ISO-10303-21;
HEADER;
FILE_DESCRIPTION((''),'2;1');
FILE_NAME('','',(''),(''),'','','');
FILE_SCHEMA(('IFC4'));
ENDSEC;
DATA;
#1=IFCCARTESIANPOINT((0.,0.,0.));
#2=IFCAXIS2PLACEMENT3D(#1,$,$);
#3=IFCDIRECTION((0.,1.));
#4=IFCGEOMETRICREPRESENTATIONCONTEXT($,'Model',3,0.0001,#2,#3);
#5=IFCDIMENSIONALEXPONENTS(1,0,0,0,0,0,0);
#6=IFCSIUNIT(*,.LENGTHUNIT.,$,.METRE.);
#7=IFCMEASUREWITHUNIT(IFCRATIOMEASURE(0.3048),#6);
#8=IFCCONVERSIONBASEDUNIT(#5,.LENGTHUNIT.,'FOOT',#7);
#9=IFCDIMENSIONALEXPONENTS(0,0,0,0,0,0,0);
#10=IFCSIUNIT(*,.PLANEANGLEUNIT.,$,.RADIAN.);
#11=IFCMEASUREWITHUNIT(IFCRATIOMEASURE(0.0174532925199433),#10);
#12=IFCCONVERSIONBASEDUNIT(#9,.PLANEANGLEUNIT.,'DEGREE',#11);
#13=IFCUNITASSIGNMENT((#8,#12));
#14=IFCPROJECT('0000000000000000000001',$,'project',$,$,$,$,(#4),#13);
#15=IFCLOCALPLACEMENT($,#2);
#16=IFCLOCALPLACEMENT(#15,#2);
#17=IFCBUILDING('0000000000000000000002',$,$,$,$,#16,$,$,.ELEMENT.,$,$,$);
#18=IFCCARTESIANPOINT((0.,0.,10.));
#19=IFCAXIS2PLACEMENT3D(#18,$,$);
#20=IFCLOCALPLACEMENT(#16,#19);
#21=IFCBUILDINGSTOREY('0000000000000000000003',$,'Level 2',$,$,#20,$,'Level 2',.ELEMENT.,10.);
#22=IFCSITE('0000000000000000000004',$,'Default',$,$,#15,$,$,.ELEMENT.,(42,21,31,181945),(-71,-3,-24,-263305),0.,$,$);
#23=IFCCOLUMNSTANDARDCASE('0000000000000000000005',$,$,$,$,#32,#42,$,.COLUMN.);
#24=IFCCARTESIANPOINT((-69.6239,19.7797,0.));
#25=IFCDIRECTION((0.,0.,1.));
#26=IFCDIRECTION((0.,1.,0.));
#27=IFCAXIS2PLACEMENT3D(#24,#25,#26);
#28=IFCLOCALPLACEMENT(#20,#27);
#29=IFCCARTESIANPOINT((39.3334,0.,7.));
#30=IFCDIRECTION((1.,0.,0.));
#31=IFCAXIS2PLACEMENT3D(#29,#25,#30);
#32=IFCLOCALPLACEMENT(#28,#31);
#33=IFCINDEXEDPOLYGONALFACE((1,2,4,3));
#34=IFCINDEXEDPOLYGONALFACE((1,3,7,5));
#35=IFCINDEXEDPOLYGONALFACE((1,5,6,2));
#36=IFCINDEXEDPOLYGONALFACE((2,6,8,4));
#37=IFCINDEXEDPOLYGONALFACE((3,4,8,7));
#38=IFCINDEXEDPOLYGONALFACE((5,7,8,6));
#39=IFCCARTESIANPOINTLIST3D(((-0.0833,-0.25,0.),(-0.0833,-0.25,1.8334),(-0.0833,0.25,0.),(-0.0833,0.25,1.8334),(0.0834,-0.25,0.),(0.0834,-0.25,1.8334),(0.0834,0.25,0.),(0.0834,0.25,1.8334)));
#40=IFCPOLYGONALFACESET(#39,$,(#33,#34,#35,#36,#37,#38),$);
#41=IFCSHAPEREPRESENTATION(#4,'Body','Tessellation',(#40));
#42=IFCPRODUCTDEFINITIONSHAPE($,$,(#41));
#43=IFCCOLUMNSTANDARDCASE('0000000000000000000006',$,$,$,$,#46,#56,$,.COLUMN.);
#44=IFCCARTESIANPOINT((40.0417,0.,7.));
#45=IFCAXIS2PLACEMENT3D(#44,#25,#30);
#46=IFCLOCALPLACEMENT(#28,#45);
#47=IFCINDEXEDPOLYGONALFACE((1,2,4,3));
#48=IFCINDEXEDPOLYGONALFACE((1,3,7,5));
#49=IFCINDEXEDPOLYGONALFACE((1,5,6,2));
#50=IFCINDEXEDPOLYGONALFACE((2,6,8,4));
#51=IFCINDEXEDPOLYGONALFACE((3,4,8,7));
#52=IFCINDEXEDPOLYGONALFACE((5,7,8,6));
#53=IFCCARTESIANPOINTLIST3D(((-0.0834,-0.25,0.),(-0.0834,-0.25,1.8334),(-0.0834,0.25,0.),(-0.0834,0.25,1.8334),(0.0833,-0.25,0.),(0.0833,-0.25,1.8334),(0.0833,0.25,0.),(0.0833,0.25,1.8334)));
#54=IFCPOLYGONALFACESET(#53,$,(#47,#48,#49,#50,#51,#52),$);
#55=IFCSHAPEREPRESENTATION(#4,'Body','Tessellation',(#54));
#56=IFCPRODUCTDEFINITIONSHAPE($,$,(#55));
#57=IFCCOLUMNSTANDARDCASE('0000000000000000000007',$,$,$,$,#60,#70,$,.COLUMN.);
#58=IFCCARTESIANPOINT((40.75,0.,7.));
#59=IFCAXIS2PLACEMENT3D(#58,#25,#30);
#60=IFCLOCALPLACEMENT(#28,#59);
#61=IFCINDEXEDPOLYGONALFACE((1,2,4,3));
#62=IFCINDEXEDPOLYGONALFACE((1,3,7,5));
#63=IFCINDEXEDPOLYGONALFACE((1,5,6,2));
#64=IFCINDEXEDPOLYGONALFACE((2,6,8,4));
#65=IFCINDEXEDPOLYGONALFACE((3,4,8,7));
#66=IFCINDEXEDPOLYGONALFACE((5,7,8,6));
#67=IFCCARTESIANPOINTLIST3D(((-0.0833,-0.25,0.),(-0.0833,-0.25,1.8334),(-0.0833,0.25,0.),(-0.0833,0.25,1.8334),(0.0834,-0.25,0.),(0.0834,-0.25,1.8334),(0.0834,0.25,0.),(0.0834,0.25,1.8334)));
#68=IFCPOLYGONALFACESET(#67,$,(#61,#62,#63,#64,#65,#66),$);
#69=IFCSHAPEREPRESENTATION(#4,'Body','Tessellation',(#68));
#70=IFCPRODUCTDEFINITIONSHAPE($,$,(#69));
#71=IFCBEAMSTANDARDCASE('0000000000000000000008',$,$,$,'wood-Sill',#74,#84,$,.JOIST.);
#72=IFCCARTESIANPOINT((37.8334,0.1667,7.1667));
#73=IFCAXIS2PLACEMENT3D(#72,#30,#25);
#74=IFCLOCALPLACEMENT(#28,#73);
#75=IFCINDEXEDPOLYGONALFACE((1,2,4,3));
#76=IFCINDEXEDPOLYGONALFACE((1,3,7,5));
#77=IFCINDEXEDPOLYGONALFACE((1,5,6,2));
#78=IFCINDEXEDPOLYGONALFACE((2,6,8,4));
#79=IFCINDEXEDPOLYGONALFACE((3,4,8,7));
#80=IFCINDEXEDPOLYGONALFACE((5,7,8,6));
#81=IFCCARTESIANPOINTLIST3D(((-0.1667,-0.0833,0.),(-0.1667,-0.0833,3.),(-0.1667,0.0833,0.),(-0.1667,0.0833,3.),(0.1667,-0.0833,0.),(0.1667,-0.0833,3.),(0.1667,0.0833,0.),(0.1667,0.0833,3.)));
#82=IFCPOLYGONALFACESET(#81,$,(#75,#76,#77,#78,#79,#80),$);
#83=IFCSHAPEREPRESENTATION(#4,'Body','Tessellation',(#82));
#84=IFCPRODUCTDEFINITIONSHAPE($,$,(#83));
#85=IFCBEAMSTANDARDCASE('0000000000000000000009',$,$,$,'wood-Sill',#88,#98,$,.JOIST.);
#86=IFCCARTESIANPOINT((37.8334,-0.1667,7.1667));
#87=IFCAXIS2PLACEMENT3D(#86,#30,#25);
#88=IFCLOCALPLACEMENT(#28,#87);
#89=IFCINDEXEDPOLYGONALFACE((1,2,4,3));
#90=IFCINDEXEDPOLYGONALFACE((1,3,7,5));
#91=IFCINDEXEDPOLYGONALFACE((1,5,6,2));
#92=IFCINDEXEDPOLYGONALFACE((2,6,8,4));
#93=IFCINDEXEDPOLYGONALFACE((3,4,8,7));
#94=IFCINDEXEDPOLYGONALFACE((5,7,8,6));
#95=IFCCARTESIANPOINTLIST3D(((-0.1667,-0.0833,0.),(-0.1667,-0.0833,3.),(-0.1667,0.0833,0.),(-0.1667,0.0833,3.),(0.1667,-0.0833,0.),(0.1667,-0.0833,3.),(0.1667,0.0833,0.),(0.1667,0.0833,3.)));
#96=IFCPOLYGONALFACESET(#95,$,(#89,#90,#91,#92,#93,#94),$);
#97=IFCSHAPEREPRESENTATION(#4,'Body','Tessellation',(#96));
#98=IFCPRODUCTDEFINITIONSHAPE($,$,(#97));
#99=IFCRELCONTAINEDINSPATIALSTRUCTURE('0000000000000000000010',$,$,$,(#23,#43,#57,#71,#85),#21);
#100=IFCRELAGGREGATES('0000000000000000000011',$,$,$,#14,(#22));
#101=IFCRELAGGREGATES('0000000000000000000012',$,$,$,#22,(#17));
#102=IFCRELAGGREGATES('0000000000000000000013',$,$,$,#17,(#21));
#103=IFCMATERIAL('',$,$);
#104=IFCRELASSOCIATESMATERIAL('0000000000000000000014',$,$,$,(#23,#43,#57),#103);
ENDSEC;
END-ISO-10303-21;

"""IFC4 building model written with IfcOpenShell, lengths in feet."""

from ifc_helpers import new_model, entity, si_unit, converted_unit, direction, frame, origin, origin_with_axes, place, context, project, spatial, rectangle, extrude, material, element, save


model = new_model("IFC4")

# Units and contexts
model_context = context("Model", 3, precision=0.0001, world=origin(), true_north=direction((0.0, 1.0)))
ifc_project = project(units=[converted_unit("LENGTHUNIT", "FOOT", entity("IfcRatioMeasure", 0.3048), si_unit("LENGTHUNIT", "METRE"), dimensions=[1, 0, 0, 0, 0, 0, 0]), converted_unit("PLANEANGLEUNIT", "DEGREE", entity("IfcRatioMeasure", 0.0174532925199433), si_unit("PLANEANGLEUNIT", "RADIAN"), dimensions=[0, 0, 0, 0, 0, 0, 0])], contexts=[model_context])

# Site, building, storey
site_placement = place(None, origin())
site = spatial("IfcSite", under=ifc_project, at=site_placement, Name="Default", CompositionType="ELEMENT", RefLatitude=(42, 21, 31, 181945), RefLongitude=(-71, -3, -24, -263305), RefElevation=0.0)
building_placement = place(site_placement, origin())
building = spatial("IfcBuilding", under=site, at=building_placement, CompositionType="ELEMENT")
storey_placement = place(building_placement, frame((0.0, 0.0, 10.0)))
storey = spatial("IfcBuildingStorey", under=building, at=storey_placement, Name="Level 2", LongName="Level 2", CompositionType="ELEMENT", Elevation=10.0)

# Columns
placement = place(storey_placement, frame((-69.6239, 19.7797, 0.0), z_axis=(0.0, 0.0, 1.0), x_axis=(0.0, 1.0, 0.0)))
ifc_material_1 = material(Name="")
for number, where, z_axis, x_axis in (
    (1, (39.3334, 0.0, 7.0), (0.0, 0.0, 1.0), (1.0, 0.0, 0.0)),
    (2, (40.0417, 0.0, 7.0), (0.0, 0.0, 1.0), (1.0, 0.0, 0.0)),
    (3, (40.75, 0.0, 7.0), (0.0, 0.0, 1.0), (1.0, 0.0, 0.0)),
):
    element("IfcColumnStandardCase", number, at=place(placement, frame(where, z_axis=z_axis, x_axis=x_axis)), inside=storey, material=ifc_material_1, PredefinedType="COLUMN", context=model_context, shape_type="SweptSolid", body=[
        extrude(rectangle(XDim=0.1667, YDim=0.5), origin(), (0.0, 0.0, 1.0), 1.8334),
    ])

# Beams
for number, where, z_axis, x_axis in (
    (4, (37.8334, 0.1667, 7.1667), (1.0, 0.0, 0.0), (0.0, 0.0, 1.0)),
    (5, (37.8334, -0.1667, 7.1667), (1.0, 0.0, 0.0), (0.0, 0.0, 1.0)),
):
    element("IfcBeamStandardCase", number, at=place(placement, frame(where, z_axis=z_axis, x_axis=x_axis)), inside=storey, ObjectType="wood-Sill", PredefinedType="JOIST", context=model_context, shape_type="SweptSolid", body=[
        extrude(rectangle(XDim=0.3333, YDim=0.1667), origin_with_axes(), (0.0, 0.0, 1.0), 3.0),
    ])

save(model, "model.ifc")
